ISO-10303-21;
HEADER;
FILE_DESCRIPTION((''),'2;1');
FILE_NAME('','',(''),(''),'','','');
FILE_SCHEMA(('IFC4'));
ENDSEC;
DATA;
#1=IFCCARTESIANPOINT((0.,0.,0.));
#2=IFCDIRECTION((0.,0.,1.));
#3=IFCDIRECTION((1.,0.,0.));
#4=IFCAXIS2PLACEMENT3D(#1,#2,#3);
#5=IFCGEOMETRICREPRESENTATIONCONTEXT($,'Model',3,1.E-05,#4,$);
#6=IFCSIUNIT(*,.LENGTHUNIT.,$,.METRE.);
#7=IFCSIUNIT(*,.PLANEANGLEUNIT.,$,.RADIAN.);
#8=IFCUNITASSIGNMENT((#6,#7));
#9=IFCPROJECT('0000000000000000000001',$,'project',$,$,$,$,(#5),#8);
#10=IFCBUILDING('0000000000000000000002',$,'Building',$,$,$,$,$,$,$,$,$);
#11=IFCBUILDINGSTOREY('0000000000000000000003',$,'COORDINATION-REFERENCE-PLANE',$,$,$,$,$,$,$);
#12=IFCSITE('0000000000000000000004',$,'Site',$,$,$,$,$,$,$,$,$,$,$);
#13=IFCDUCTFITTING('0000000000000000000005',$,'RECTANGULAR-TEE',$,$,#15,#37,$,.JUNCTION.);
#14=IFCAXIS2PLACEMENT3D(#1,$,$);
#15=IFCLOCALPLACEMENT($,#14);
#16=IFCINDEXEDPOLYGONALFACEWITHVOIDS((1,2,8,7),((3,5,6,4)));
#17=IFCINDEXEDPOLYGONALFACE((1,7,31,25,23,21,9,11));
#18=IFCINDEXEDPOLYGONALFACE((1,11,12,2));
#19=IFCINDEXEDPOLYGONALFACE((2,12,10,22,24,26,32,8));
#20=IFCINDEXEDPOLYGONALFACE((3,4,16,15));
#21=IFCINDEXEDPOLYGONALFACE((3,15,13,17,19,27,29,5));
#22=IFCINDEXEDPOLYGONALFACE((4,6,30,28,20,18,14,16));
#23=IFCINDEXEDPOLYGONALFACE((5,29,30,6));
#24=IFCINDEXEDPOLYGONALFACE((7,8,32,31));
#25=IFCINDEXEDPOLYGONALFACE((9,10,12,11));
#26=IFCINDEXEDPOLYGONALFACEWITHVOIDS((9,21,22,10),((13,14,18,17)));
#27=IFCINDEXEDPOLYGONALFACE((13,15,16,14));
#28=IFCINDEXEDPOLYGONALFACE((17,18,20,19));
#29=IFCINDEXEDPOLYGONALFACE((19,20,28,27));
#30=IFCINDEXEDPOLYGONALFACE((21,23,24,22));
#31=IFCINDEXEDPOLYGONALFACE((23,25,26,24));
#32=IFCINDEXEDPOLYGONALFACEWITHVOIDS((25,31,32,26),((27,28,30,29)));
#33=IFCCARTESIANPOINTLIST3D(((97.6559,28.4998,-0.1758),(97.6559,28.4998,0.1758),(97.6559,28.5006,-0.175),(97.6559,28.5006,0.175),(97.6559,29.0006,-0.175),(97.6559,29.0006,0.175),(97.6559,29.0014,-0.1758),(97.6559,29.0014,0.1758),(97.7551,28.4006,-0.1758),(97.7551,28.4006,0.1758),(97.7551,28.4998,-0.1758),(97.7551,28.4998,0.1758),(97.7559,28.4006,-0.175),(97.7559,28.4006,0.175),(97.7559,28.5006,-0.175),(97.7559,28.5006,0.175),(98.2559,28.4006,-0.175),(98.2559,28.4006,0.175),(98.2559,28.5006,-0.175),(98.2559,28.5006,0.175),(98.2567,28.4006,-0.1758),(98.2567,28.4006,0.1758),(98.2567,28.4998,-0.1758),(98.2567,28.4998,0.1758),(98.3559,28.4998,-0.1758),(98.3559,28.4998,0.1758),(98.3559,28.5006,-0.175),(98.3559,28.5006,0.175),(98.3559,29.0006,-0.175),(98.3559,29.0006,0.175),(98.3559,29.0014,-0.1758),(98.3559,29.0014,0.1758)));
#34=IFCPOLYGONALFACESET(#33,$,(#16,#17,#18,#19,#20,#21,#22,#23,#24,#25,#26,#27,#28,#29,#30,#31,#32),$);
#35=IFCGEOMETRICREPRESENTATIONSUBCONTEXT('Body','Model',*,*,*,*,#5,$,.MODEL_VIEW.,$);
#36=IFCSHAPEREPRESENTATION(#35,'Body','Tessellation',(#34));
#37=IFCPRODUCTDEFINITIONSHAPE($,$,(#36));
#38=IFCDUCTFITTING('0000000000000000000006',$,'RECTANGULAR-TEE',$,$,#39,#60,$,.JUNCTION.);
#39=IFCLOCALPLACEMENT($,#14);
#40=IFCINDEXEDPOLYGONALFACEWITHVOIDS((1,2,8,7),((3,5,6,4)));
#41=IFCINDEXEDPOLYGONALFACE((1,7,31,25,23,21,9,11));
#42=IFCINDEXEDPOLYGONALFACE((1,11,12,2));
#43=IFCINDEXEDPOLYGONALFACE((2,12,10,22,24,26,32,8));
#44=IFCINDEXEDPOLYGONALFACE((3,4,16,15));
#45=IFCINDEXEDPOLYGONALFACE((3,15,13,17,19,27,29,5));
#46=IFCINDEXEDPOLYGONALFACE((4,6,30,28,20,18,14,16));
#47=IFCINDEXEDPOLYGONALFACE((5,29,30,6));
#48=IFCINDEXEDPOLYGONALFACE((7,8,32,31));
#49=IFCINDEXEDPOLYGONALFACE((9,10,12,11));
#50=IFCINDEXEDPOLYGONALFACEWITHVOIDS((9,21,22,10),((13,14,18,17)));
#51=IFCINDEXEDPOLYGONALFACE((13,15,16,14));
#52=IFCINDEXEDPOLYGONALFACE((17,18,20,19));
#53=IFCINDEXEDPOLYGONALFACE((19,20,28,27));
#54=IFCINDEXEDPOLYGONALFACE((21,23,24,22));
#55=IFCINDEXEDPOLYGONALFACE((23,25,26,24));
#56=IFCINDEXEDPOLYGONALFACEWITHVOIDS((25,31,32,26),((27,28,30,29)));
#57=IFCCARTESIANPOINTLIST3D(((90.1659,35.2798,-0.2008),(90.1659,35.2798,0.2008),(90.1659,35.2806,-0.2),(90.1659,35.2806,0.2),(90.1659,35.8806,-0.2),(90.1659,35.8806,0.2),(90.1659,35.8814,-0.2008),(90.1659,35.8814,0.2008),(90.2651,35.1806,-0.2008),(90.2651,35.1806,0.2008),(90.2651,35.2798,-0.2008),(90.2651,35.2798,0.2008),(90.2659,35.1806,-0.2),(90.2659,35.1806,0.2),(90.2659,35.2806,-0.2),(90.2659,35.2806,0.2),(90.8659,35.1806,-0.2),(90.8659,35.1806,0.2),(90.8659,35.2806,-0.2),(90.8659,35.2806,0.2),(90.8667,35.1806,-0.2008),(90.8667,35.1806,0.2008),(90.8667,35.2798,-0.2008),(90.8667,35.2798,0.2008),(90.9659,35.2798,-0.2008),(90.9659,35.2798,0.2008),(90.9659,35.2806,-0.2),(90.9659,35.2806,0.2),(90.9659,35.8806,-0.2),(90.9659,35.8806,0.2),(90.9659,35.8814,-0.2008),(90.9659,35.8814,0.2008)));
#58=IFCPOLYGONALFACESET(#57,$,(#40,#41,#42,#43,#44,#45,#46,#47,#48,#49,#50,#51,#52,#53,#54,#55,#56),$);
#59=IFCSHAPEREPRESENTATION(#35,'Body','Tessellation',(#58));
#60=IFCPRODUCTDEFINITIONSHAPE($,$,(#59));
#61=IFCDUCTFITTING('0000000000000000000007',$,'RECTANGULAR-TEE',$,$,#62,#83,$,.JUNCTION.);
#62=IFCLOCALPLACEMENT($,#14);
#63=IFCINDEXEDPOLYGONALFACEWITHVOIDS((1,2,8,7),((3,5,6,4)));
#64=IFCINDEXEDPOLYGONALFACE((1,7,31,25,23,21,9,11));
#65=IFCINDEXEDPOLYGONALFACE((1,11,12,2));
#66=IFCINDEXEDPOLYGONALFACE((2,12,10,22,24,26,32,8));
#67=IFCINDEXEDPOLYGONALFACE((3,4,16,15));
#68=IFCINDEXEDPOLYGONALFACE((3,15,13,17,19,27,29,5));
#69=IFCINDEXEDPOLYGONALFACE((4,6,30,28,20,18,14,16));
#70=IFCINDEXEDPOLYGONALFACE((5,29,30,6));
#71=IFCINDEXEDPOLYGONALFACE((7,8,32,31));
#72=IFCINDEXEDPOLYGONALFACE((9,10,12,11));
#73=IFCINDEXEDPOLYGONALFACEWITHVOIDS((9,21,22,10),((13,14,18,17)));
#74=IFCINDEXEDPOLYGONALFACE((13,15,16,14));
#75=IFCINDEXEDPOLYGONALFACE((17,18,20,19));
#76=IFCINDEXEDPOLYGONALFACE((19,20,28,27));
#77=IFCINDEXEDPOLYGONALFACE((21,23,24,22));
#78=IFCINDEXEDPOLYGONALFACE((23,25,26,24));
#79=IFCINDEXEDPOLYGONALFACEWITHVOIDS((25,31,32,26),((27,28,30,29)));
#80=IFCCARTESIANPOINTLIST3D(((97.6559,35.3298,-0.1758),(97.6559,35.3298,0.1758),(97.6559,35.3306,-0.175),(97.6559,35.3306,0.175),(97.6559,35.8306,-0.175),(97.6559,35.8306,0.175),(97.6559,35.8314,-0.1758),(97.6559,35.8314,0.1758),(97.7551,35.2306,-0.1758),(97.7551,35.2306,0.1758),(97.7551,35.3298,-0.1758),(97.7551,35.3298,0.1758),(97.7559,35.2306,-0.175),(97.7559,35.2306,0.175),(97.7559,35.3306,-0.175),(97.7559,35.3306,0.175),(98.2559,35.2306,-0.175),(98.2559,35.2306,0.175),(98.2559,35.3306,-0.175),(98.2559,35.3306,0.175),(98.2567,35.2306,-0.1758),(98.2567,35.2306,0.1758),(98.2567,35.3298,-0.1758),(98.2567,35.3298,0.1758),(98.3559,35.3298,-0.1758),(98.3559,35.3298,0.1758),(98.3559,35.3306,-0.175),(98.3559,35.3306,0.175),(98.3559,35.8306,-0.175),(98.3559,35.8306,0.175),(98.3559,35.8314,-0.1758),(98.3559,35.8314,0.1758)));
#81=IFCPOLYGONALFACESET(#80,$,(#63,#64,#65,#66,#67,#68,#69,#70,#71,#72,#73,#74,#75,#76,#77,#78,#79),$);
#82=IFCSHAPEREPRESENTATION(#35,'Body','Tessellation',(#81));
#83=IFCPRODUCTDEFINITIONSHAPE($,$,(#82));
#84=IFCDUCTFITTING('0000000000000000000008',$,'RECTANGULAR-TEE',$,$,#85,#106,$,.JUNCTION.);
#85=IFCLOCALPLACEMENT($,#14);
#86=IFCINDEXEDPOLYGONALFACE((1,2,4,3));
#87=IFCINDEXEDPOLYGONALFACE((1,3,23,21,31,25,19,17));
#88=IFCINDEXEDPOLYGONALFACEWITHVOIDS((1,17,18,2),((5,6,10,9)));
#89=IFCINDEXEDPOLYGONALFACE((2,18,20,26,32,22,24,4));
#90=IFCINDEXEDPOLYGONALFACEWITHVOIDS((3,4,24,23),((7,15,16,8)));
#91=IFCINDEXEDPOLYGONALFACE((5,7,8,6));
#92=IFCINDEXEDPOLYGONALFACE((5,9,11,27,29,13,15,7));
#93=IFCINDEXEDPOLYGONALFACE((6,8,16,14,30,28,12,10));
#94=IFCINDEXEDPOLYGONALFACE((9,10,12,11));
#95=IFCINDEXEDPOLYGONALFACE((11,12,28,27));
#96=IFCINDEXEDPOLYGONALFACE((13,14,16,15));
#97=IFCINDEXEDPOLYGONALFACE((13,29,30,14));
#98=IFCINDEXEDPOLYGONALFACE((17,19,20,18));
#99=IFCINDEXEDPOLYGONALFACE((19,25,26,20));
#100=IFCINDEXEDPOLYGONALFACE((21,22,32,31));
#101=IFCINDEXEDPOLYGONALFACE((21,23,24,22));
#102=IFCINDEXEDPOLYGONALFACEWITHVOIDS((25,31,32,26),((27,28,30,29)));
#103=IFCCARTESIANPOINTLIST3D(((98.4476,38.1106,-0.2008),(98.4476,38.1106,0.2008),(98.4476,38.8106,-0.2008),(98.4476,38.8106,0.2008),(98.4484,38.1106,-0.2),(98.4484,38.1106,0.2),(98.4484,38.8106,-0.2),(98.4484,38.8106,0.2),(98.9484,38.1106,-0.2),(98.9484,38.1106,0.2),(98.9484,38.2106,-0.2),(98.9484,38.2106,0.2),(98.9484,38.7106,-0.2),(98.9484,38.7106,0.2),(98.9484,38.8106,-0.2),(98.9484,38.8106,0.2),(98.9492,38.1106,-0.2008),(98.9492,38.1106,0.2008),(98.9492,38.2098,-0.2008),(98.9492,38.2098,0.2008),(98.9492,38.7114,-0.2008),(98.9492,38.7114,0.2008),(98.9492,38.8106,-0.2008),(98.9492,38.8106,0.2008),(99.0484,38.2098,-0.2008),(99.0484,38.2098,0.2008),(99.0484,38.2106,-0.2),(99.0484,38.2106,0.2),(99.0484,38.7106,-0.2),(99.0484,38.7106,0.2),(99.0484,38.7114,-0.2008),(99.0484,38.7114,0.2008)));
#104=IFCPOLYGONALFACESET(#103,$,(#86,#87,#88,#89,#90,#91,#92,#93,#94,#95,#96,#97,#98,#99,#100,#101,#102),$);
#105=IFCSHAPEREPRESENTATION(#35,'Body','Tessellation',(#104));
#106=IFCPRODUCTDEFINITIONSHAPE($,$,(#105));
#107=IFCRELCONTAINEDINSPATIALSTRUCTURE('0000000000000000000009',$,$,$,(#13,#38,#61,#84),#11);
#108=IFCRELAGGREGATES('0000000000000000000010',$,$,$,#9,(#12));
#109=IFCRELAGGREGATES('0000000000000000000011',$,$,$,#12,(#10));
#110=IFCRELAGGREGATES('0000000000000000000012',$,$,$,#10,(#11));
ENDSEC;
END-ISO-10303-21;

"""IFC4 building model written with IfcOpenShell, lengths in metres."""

from ifc_helpers import new_model, si_unit, frame, origin_with_axes, place, context, subcontext, project, spatial, rectangle, extrude, boolean, element, save


model = new_model("IFC4")

# Units and contexts
model_context = context("Model", 3, precision=1e-05, world=origin_with_axes())
body_context = subcontext(model_context, "Body", "Model", "MODEL_VIEW")
ifc_project = project(units=[si_unit("LENGTHUNIT", "METRE"), si_unit("PLANEANGLEUNIT", "RADIAN")], contexts=[model_context])

# Site, building, storey
site = spatial("IfcSite", under=ifc_project, Name="Site")
building = spatial("IfcBuilding", under=site, Name="Building")
storey = spatial("IfcBuildingStorey", under=building, Name="COORDINATION-REFERENCE-PLANE")

# Duct fittings
duct_fitting_1_placement = place(None, frame((98.0059, 28.7506, 0.0), z_axis=(1.0, 0.0, 0.0), x_axis=(0.0, -1.0, 0.0)))
solid_1 = boolean("UNION", extrude(rectangle(XDim=0.5, YDim=0.35), frame((0.0, 0.0, -0.35), z_axis=(0.0, 0.0, 1.0), x_axis=(1.0, 0.0, 0.0)), (0.0, 0.0, 1.0), 0.7), extrude(rectangle(XDim=0.5, YDim=0.35), frame((0.0, 0.0, 0.0), z_axis=(1.0, 0.0, 0.0), x_axis=(0.0, 0.0, -1.0)), (0.0, 0.0, 1.0), 0.35))
element("IfcDuctFitting", 1, at=duct_fitting_1_placement, inside=storey, Name="RECTANGULAR-TEE", PredefinedType="JUNCTION", context=body_context, shape_type="CSG", body=[
    boolean("DIFFERENCE", boolean("UNION", extrude(rectangle(XDim=0.5016, YDim=0.3516), frame((0.0, 0.0, -0.35), z_axis=(0.0, 0.0, 1.0), x_axis=(1.0, 0.0, 0.0)), (0.0, 0.0, 1.0), 0.7), extrude(rectangle(XDim=0.5016, YDim=0.3516), frame((0.0, 0.0, 0.0), z_axis=(1.0, 0.0, 0.0), x_axis=(0.0, 0.0, -1.0)), (0.0, 0.0, 1.0), 0.35)), solid_1),
])
duct_fitting_2_placement = place(None, frame((90.5659, 35.5806, 0.0), z_axis=(1.0, 0.0, 0.0), x_axis=(0.0, -1.0, 0.0)))
solid_2 = boolean("UNION", extrude(rectangle(XDim=0.6, YDim=0.4), frame((0.0, 0.0, -0.4), z_axis=(0.0, 0.0, 1.0), x_axis=(1.0, 0.0, 0.0)), (0.0, 0.0, 1.0), 0.8), extrude(rectangle(XDim=0.6, YDim=0.4), frame((0.0, 0.0, 0.0), z_axis=(1.0, 0.0, 0.0), x_axis=(0.0, 0.0, -1.0)), (0.0, 0.0, 1.0), 0.4))
element("IfcDuctFitting", 2, at=duct_fitting_2_placement, inside=storey, Name="RECTANGULAR-TEE", PredefinedType="JUNCTION", context=body_context, shape_type="CSG", body=[
    boolean("DIFFERENCE", boolean("UNION", extrude(rectangle(XDim=0.6016, YDim=0.4016), frame((0.0, 0.0, -0.4), z_axis=(0.0, 0.0, 1.0), x_axis=(1.0, 0.0, 0.0)), (0.0, 0.0, 1.0), 0.8), extrude(rectangle(XDim=0.6016, YDim=0.4016), frame((0.0, 0.0, 0.0), z_axis=(1.0, 0.0, 0.0), x_axis=(0.0, 0.0, -1.0)), (0.0, 0.0, 1.0), 0.4)), solid_2),
])
duct_fitting_3_placement = place(None, frame((98.0059, 35.5806, 0.0), z_axis=(1.0, 0.0, 0.0), x_axis=(0.0, -1.0, 0.0)))
solid_3 = boolean("UNION", extrude(rectangle(XDim=0.5, YDim=0.35), frame((0.0, 0.0, -0.35), z_axis=(0.0, 0.0, 1.0), x_axis=(1.0, 0.0, 0.0)), (0.0, 0.0, 1.0), 0.7), extrude(rectangle(XDim=0.5, YDim=0.35), frame((0.0, 0.0, 0.0), z_axis=(1.0, 0.0, 0.0), x_axis=(0.0, 0.0, -1.0)), (0.0, 0.0, 1.0), 0.35))
element("IfcDuctFitting", 3, at=duct_fitting_3_placement, inside=storey, Name="RECTANGULAR-TEE", PredefinedType="JUNCTION", context=body_context, shape_type="CSG", body=[
    boolean("DIFFERENCE", boolean("UNION", extrude(rectangle(XDim=0.5016, YDim=0.3516), frame((0.0, 0.0, -0.35), z_axis=(0.0, 0.0, 1.0), x_axis=(1.0, 0.0, 0.0)), (0.0, 0.0, 1.0), 0.7), extrude(rectangle(XDim=0.5016, YDim=0.3516), frame((0.0, 0.0, 0.0), z_axis=(1.0, 0.0, 0.0), x_axis=(0.0, 0.0, -1.0)), (0.0, 0.0, 1.0), 0.35)), solid_3),
])
duct_fitting_4_placement = place(None, frame((98.6984, 38.4606, 0.0), z_axis=(0.0, 1.0, 0.0), x_axis=(1.0, 0.0, 0.0)))
solid_4 = boolean("UNION", extrude(rectangle(XDim=0.5, YDim=0.4), frame((0.0, 0.0, -0.35), z_axis=(0.0, 0.0, 1.0), x_axis=(1.0, 0.0, 0.0)), (0.0, 0.0, 1.0), 0.7), extrude(rectangle(XDim=0.5, YDim=0.4), frame((0.0, 0.0, 0.0), z_axis=(1.0, 0.0, 0.0), x_axis=(0.0, 0.0, -1.0)), (0.0, 0.0, 1.0), 0.35))
element("IfcDuctFitting", 4, at=duct_fitting_4_placement, inside=storey, Name="RECTANGULAR-TEE", PredefinedType="JUNCTION", context=body_context, shape_type="CSG", body=[
    boolean("DIFFERENCE", boolean("UNION", extrude(rectangle(XDim=0.5016, YDim=0.4016), frame((0.0, 0.0, -0.35), z_axis=(0.0, 0.0, 1.0), x_axis=(1.0, 0.0, 0.0)), (0.0, 0.0, 1.0), 0.7), extrude(rectangle(XDim=0.5016, YDim=0.4016), frame((0.0, 0.0, 0.0), z_axis=(1.0, 0.0, 0.0), x_axis=(0.0, 0.0, -1.0)), (0.0, 0.0, 1.0), 0.35)), solid_4),
])

save(model, "model.ifc")
